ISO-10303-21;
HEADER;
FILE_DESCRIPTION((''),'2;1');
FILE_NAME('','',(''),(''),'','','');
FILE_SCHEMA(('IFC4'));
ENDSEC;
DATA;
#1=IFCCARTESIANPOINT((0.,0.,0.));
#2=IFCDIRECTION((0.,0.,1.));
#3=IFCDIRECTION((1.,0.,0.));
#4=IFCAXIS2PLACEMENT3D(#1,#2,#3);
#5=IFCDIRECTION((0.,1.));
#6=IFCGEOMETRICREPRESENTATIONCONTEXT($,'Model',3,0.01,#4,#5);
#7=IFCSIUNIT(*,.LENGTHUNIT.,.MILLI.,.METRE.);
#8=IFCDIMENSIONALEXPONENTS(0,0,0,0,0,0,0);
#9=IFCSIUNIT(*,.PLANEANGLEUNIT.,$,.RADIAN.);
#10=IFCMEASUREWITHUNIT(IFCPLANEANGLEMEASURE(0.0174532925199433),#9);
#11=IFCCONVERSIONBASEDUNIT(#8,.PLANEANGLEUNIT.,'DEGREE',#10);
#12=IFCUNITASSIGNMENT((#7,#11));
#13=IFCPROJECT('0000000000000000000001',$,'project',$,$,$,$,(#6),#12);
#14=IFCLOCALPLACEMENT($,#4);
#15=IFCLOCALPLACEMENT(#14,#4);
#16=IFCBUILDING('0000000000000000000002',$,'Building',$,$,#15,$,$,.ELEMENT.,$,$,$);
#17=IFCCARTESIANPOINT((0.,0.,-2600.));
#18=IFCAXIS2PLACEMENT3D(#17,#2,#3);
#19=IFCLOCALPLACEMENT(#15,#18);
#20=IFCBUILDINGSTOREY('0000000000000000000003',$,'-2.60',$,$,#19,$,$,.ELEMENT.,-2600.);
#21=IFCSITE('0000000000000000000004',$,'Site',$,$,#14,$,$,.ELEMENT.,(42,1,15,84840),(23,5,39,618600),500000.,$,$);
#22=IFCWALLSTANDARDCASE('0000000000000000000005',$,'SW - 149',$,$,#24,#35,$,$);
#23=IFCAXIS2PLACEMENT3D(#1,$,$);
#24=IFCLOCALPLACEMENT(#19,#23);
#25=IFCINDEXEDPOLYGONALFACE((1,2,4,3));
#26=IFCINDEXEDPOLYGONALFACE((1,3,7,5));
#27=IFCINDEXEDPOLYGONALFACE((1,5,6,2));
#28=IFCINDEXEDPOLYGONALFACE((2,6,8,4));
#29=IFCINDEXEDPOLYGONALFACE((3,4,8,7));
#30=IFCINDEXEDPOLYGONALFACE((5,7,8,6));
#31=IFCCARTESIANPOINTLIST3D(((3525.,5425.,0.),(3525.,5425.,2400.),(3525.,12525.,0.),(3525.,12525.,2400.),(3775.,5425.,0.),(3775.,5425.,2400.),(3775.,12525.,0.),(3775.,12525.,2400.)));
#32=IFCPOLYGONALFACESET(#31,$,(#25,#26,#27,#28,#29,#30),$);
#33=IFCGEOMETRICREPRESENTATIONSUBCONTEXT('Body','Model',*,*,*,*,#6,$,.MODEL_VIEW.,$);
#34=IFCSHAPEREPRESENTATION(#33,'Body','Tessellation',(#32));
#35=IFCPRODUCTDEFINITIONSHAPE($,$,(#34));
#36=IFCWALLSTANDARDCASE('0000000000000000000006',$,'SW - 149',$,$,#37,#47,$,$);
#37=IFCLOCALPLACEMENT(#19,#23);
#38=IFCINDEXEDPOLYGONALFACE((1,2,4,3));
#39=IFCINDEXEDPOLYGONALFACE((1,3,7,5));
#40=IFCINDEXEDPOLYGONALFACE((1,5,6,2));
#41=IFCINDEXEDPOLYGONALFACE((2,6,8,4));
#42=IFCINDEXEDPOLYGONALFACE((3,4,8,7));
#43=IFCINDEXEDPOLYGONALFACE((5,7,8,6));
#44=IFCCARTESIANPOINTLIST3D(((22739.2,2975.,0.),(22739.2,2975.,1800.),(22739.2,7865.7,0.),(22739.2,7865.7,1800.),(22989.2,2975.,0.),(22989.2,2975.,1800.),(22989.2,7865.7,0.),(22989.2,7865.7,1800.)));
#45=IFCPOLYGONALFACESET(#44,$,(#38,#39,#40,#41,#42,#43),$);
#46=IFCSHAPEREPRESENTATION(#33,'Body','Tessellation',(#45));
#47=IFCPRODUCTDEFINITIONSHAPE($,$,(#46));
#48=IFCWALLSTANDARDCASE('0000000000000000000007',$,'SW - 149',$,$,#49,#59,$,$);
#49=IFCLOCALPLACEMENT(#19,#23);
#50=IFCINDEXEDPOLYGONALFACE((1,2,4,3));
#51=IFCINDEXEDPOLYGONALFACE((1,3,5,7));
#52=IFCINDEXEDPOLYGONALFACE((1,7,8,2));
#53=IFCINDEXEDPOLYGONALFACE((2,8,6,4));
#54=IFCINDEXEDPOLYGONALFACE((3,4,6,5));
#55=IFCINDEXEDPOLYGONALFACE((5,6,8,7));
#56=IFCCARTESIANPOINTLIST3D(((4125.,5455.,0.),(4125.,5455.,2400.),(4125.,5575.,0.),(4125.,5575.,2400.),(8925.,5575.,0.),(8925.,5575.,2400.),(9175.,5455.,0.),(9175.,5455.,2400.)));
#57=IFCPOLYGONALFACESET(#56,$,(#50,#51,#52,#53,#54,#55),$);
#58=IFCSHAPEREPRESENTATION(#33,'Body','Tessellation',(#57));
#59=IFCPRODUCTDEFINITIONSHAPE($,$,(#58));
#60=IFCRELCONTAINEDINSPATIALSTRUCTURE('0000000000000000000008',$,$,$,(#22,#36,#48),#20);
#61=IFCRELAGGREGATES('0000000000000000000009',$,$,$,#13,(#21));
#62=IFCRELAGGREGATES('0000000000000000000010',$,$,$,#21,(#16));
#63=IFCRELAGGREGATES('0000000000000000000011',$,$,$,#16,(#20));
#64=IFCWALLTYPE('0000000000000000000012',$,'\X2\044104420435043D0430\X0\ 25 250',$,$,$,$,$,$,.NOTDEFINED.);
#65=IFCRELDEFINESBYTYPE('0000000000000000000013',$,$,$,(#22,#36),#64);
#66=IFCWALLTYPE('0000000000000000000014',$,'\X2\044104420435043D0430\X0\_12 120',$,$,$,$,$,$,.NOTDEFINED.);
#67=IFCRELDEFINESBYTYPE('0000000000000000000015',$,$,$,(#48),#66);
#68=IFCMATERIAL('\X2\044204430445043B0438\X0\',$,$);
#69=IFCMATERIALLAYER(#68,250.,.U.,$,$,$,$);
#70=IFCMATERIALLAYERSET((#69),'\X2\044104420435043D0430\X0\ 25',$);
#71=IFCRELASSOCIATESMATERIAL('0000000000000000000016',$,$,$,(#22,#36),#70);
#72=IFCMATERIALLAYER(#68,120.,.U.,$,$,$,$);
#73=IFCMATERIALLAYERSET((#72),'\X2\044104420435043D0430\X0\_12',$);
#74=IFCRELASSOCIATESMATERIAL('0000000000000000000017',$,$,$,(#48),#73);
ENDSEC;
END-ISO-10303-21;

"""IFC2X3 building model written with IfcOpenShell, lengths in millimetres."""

from ifc_helpers import new_model, entity, si_unit, converted_unit, direction, frame, origin_with_axes, place, context, subcontext, project, spatial, polyline, outline, extrude, material, layer, layer_set, layer_usage, type_object, element, save


model = new_model("IFC2X3")

# Units and contexts
model_context = context("Model", 3, precision=0.01, world=origin_with_axes(), true_north=direction((0.0, 1.0)))
body_context = subcontext(model_context, "Body", "Model", "MODEL_VIEW")
ifc_project = project(units=[si_unit("LENGTHUNIT", "METRE", prefix="MILLI"), converted_unit("PLANEANGLEUNIT", "DEGREE", entity("IfcPlaneAngleMeasure", 0.0174532925199433), si_unit("PLANEANGLEUNIT", "RADIAN"), dimensions=[0, 0, 0, 0, 0, 0, 0])], contexts=[model_context])

# Site, building, storey
site_placement = place(None, origin_with_axes())
site = spatial("IfcSite", under=ifc_project, at=site_placement, Name="Site", CompositionType="ELEMENT", RefLatitude=(42, 1, 15, 84840), RefLongitude=(23, 5, 39, 618600), RefElevation=500000.0)
building_placement = place(site_placement, origin_with_axes())
building = spatial("IfcBuilding", under=site, at=building_placement, Name="Building", CompositionType="ELEMENT")
storey_placement = place(building_placement, frame((0.0, 0.0, -2600.0), z_axis=(0.0, 0.0, 1.0), x_axis=(1.0, 0.0, 0.0)))
storey = spatial("IfcBuildingStorey", under=building, at=storey_placement, Name="-2.60", CompositionType="ELEMENT", Elevation=-2600.0)

# Shared definitions
ifc_material_1 = material(Name="тухли")

# Shared definitions
ifc_layer_1 = layer(ifc_material_1, 250.0, ventilated="UNKNOWN")
ifc_layer_set_1 = layer_set([ifc_layer_1], Name="стена 25")
wall_type_1 = type_object("IfcWallType", Name="стена 25 250", PredefinedType="NOTDEFINED")

# Walls
ifc_layer_usage_1 = layer_usage(ifc_layer_set_1, "AXIS2", "NEGATIVE", 0.0)
wall_1_placement = place(storey_placement, frame((3525.0, 5425.0, 0.0), z_axis=(0.0, 0.0, 1.0), x_axis=(0.0, 1.0, 0.0)))
element("IfcWallStandardCase", 1, at=wall_1_placement, inside=storey, type_object=wall_type_1, material=ifc_layer_usage_1, Name="SW - 149", context=body_context, shape_type="SweptSolid", body=[
    extrude(outline(polyline([(0.0, -250.0), (7100.0, -250.0), (7100.0, 0.0), (0.0, 0.0), (0.0, -250.0)])), origin_with_axes(), (0.0, 0.0, 1.0), 2400.0),
])
ifc_layer_usage_2 = layer_usage(ifc_layer_set_1, "AXIS2", "NEGATIVE", 0.0)
wall_2_placement = place(storey_placement, frame((22739.2, 2975.0, 0.0), z_axis=(0.0, 0.0, 1.0), x_axis=(0.0, 1.0, 0.0)))
element("IfcWallStandardCase", 2, at=wall_2_placement, inside=storey, type_object=wall_type_1, material=ifc_layer_usage_2, Name="SW - 149", context=body_context, shape_type="SweptSolid", body=[
    extrude(outline(polyline([(0.0, -250.0), (4890.7, -250.0), (4890.7, 0.0), (0.0, 0.0), (0.0, -250.0)])), origin_with_axes(), (0.0, 0.0, 1.0), 1800.0),
])
ifc_layer_2 = layer(ifc_material_1, 120.0, ventilated="UNKNOWN")
ifc_layer_set_2 = layer_set([ifc_layer_2], Name="стена_12")
ifc_layer_usage_3 = layer_usage(ifc_layer_set_2, "AXIS2", "NEGATIVE", 0.0)
wall_type_2 = type_object("IfcWallType", Name="стена_12 120", PredefinedType="NOTDEFINED")
wall_3_placement = place(storey_placement, frame((3875.0, 5575.0, 0.0), z_axis=(0.0, 0.0, 1.0), x_axis=(1.0, 0.0, 0.0)))
element("IfcWallStandardCase", 3, at=wall_3_placement, inside=storey, type_object=wall_type_2, material=ifc_layer_usage_3, Name="SW - 149", context=body_context, shape_type="SweptSolid", body=[
    extrude(outline(polyline([(250.0, -120.0), (5300.0, -120.0), (5050.0, 0.0), (250.0, 0.0), (250.0, -120.0)])), origin_with_axes(), (0.0, 0.0, 1.0), 2400.0),
])

save(model, "model.ifc")
